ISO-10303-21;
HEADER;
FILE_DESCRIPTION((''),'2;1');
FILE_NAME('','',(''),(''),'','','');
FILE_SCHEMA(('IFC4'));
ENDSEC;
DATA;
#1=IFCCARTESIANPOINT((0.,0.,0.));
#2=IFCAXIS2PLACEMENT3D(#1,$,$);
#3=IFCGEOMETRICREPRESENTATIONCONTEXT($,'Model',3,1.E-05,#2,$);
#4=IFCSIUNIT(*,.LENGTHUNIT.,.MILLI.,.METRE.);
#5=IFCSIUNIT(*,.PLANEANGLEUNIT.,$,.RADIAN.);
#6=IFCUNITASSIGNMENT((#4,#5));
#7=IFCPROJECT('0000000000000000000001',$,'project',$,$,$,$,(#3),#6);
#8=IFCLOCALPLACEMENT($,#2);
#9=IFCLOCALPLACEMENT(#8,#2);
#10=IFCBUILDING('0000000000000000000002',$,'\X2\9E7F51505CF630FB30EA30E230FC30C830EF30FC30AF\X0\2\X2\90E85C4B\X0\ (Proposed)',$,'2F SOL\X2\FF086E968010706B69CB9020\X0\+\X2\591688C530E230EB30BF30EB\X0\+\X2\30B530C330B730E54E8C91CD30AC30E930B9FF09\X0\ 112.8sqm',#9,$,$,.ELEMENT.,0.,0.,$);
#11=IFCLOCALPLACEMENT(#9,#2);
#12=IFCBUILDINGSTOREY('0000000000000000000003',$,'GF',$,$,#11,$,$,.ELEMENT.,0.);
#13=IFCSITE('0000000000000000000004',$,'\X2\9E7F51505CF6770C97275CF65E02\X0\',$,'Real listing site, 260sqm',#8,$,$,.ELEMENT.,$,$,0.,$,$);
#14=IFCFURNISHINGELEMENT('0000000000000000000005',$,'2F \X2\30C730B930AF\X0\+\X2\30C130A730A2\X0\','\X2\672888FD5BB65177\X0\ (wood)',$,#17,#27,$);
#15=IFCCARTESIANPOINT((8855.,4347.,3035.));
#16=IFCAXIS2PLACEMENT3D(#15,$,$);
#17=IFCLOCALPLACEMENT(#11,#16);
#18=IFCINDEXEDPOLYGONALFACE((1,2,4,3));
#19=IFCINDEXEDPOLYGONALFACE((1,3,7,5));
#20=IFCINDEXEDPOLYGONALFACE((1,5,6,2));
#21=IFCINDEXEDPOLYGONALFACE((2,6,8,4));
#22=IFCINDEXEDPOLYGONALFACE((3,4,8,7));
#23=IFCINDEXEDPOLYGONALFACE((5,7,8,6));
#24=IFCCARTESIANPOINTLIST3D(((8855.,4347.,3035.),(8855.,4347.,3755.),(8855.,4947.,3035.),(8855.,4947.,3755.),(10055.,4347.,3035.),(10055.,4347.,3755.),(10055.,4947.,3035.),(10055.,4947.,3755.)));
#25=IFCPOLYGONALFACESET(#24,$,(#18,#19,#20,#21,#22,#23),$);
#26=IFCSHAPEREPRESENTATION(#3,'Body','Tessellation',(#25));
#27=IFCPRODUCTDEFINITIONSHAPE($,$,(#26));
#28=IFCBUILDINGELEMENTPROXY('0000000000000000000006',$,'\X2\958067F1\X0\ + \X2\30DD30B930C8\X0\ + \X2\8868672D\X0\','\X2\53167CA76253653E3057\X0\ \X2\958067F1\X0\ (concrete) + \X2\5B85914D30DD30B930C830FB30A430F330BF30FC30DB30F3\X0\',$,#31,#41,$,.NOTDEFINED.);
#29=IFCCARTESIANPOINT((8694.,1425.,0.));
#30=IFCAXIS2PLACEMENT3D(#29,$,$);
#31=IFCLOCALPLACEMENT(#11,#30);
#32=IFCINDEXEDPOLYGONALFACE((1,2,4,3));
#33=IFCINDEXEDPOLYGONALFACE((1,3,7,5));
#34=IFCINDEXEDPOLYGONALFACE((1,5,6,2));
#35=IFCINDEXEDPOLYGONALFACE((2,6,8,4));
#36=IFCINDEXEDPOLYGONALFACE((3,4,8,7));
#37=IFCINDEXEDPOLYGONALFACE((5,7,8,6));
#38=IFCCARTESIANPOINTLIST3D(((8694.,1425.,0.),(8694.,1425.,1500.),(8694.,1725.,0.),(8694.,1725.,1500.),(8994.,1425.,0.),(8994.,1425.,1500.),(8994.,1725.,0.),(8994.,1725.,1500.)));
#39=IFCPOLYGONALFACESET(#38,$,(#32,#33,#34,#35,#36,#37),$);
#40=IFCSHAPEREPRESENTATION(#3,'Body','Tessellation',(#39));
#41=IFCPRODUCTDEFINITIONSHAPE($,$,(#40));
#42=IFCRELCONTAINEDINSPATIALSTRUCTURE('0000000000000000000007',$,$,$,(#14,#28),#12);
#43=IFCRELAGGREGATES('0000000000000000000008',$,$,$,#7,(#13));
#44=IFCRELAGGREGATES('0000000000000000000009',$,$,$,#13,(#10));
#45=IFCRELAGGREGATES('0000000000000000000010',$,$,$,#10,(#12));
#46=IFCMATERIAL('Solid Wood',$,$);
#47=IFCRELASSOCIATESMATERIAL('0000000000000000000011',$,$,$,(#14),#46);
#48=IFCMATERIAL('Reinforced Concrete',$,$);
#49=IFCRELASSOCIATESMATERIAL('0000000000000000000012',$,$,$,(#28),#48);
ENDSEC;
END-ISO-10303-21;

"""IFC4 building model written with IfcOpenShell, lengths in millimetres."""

from ifc_helpers import new_model, si_unit, frame, frame_2d, origin, place, context, project, spatial, rectangle, extrude, material, element, save


model = new_model("IFC4")

# Units and contexts
model_context = context("Model", 3, precision=1e-05, world=origin())
ifc_project = project(units=[si_unit("LENGTHUNIT", "METRE", prefix="MILLI"), si_unit("PLANEANGLEUNIT", "RADIAN")], contexts=[model_context])

# Site, building, storey
site_placement = place(None, origin())
site = spatial("IfcSite", under=ifc_project, at=site_placement, Name="鹿児島県霧島市", ObjectType="Real listing site, 260sqm", CompositionType="ELEMENT", RefElevation=0.0)
building_placement = place(site_placement, origin())
building = spatial("IfcBuilding", under=site, at=building_placement, Name="鹿児島・リモートワーク2部屋 (Proposed)", ObjectType="2F SOL（準耐火構造+外装モルタル+サッシュ二重ガラス） 112.8sqm", CompositionType="ELEMENT", ElevationOfRefHeight=0.0, ElevationOfTerrain=0.0)
storey_placement = place(building_placement, origin())
storey = spatial("IfcBuildingStorey", under=building, at=storey_placement, Name="GF", CompositionType="ELEMENT", Elevation=0.0)

# Shared definitions
ifc_material_1 = material(Name="Solid Wood")

# Shared definitions
ifc_material_2 = material(Name="Reinforced Concrete")

# Furnishing element
furnishing_1_placement = place(storey_placement, frame((8855.0, 4347.0, 3035.0)))
element("IfcFurnishingElement", 1, at=furnishing_1_placement, inside=storey, material=ifc_material_1, Name="2F デスク+チェア", Description="木製家具 (wood)", context=model_context, shape_type="SweptSolid", body=[
    extrude(rectangle(XDim=1200.0, YDim=600.0, at=frame_2d((600.0, 300.0))), frame((8855.0, 4347.0, 3035.0)), (0.0, 0.0, 1.0), 720.0),
])

# Building element proxy
proxy_placement = place(storey_placement, frame((8694.0, 1425.0, 0.0)))
element("IfcBuildingElementProxy", 2, at=proxy_placement, inside=storey, material=ifc_material_2, Name="門柱 + ポスト + 表札", Description="化粧打放し 門柱 (concrete) + 宅配ポスト・インターホン", PredefinedType="NOTDEFINED", context=model_context, shape_type="SweptSolid", body=[
    extrude(rectangle(XDim=300.0, YDim=300.0, at=frame_2d((150.0, 150.0))), frame((8694.0, 1425.0, 0.0)), (0.0, 0.0, 1.0), 1500.0),
])

save(model, "model.ifc")
